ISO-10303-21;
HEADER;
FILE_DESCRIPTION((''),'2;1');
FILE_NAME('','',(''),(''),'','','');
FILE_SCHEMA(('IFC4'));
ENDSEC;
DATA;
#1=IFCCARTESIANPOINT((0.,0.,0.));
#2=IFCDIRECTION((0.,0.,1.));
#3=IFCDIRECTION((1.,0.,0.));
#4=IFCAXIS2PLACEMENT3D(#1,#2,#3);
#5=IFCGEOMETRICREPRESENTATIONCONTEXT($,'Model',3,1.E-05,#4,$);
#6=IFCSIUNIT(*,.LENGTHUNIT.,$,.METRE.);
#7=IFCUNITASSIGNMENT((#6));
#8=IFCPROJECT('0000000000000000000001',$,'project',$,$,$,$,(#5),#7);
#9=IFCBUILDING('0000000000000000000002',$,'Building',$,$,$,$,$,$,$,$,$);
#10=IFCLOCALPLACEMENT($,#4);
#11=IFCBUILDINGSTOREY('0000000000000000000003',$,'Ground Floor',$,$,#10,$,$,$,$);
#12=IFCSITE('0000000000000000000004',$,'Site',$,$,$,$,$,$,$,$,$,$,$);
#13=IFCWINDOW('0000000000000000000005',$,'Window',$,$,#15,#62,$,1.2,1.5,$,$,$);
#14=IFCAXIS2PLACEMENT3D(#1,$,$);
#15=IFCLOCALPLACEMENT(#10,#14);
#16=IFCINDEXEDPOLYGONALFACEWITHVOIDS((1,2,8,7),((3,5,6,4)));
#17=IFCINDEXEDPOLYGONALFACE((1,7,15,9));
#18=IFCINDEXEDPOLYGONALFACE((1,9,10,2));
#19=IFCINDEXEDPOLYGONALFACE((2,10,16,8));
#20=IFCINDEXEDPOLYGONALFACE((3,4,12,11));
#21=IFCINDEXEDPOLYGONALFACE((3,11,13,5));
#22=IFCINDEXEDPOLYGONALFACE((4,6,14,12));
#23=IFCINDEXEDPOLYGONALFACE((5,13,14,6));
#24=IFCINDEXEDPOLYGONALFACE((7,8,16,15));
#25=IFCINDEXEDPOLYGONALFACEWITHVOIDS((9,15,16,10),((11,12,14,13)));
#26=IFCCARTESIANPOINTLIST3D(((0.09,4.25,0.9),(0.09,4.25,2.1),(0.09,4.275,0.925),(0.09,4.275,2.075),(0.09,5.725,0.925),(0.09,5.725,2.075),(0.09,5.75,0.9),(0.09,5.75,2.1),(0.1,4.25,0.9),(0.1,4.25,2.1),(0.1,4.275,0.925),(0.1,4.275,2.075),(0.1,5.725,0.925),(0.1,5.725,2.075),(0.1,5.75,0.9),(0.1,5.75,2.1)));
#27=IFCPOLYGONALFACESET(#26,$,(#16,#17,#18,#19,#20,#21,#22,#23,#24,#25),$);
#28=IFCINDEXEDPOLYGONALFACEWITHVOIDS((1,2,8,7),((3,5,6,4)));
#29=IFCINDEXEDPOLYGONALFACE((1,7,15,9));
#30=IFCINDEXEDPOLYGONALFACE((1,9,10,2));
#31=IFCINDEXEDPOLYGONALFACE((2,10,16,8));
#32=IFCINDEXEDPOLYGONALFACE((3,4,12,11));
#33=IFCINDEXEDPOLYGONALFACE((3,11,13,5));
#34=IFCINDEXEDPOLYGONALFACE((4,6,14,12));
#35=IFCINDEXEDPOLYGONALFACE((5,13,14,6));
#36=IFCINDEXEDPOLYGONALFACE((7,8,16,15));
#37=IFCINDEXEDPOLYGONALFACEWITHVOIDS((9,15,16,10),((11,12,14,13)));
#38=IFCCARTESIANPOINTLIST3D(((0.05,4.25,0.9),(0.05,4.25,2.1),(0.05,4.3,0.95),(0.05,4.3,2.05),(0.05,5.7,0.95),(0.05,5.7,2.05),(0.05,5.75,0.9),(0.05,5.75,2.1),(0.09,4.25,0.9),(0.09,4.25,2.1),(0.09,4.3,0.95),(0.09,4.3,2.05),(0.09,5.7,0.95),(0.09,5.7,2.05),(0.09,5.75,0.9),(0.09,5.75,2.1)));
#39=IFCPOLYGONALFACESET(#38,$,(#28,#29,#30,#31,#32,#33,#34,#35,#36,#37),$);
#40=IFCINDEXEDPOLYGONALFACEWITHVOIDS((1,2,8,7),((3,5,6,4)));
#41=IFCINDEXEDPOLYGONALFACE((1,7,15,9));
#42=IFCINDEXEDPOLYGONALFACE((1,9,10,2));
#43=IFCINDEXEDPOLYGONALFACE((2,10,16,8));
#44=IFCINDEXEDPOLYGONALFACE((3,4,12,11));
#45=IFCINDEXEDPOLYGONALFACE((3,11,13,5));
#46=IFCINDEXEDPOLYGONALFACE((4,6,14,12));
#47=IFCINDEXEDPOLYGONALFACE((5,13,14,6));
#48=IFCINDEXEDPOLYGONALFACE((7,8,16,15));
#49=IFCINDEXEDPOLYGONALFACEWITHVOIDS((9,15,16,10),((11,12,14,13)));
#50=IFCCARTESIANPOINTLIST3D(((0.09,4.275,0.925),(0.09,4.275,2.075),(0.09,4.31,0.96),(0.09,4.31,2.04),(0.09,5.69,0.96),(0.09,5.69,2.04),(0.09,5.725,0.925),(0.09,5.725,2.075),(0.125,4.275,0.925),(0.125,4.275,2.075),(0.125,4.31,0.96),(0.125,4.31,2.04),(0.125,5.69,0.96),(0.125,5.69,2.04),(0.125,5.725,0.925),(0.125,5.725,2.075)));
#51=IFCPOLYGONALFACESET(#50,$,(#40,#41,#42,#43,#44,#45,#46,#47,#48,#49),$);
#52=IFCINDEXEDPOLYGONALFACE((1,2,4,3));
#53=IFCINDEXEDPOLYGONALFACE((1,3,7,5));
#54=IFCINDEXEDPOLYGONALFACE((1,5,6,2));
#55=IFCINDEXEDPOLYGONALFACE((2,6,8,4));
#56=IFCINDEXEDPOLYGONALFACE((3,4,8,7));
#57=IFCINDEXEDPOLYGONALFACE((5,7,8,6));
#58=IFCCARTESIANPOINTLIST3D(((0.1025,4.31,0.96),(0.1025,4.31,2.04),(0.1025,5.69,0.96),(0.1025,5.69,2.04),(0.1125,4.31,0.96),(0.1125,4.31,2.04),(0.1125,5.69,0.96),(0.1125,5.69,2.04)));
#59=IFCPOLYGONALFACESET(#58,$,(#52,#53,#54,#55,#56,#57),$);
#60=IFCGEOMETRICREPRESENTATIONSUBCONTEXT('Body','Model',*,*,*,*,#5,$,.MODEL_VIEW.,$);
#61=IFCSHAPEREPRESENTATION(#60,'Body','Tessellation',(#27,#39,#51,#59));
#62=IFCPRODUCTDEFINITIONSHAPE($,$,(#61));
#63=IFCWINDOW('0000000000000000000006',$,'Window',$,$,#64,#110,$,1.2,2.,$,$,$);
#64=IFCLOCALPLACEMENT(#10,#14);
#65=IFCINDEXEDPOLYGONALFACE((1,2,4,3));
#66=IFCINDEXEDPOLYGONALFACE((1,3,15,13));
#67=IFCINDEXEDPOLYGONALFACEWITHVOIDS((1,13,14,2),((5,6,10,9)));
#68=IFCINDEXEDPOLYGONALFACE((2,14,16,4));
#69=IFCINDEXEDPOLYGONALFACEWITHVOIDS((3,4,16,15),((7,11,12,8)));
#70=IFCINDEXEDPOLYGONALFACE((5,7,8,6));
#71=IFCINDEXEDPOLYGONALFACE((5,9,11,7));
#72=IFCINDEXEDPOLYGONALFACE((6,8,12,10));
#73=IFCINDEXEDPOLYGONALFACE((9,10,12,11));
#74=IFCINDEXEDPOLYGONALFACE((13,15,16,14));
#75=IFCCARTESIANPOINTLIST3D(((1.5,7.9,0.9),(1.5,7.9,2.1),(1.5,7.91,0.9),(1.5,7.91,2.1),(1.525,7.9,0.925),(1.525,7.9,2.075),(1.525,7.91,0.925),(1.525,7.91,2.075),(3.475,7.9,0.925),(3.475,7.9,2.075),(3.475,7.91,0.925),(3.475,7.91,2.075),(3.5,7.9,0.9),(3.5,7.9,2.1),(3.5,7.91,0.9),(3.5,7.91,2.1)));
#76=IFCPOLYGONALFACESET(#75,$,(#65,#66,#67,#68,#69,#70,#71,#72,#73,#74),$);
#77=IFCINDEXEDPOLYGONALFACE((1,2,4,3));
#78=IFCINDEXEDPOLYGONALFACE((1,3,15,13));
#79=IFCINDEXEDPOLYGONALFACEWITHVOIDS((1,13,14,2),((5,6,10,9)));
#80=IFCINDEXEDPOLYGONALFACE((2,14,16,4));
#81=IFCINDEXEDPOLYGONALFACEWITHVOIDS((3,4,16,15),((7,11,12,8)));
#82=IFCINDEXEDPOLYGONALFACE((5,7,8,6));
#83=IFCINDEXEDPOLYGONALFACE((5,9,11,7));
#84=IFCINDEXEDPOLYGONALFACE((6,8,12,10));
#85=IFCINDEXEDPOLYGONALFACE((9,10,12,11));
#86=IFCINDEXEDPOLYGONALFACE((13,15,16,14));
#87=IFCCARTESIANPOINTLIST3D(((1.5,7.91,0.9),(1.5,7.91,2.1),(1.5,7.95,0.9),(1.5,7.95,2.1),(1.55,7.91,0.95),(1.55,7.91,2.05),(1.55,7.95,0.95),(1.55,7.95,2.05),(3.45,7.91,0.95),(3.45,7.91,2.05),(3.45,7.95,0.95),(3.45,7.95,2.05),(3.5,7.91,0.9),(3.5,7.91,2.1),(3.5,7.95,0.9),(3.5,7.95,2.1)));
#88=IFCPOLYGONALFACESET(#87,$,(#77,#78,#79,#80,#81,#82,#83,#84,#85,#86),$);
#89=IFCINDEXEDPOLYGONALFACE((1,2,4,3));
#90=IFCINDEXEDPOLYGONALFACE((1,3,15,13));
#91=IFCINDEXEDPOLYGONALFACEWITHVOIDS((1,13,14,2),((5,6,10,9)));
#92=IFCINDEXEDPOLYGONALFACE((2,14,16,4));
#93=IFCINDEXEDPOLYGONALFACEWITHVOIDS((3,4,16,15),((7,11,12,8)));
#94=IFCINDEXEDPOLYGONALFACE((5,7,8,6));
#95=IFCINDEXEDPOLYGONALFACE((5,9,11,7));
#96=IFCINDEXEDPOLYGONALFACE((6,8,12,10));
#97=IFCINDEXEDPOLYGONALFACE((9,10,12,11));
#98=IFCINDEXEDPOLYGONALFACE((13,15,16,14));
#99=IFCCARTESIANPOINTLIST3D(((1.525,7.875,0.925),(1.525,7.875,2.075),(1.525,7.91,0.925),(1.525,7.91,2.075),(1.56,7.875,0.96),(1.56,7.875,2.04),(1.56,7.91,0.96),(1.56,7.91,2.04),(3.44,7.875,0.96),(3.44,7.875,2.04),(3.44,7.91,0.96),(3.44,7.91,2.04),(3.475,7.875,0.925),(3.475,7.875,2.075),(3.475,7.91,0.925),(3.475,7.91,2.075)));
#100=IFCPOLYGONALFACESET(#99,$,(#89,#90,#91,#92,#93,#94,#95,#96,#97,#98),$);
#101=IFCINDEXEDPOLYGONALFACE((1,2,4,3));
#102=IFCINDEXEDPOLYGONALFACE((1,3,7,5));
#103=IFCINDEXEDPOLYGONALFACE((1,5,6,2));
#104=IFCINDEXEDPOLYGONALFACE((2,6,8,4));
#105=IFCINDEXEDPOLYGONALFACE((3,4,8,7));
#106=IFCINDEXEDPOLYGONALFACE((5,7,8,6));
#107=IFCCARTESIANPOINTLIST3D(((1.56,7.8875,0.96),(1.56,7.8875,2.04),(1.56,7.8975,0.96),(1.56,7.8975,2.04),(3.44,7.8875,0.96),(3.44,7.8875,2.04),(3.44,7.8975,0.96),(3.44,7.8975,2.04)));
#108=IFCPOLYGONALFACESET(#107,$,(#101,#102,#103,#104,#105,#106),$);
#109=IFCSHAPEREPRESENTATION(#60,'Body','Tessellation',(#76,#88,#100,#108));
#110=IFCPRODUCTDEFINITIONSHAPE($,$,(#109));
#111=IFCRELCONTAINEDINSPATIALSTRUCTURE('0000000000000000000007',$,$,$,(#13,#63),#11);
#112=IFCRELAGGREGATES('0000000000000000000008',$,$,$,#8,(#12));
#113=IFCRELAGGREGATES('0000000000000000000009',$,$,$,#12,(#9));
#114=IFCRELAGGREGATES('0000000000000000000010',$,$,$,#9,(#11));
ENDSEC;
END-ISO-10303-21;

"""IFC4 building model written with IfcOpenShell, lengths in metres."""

from ifc_helpers import new_model, si_unit, frame, origin_with_axes, place, context, subcontext, project, spatial, line, indexed_curve, outline, extrude, element, save


model = new_model("IFC4")

# Units and contexts
model_context = context("Model", 3, precision=1e-05, world=origin_with_axes())
body_context = subcontext(model_context, "Body", "Model", "MODEL_VIEW")
ifc_project = project(units=[si_unit("LENGTHUNIT", "METRE")], contexts=[model_context])

# Site, building, storey
site = spatial("IfcSite", under=ifc_project, Name="Site")
building = spatial("IfcBuilding", under=site, Name="Building")
storey_placement = place(None, origin_with_axes())
storey = spatial("IfcBuildingStorey", under=building, at=storey_placement, Name="Ground Floor")

# Windows
for number, where, z_axis, x_axis, name in (
    (1, (0.0, 5.75, 0.9), (0.0, 0.0, 1.0), (0.0, -1.0, 0.0), "Window"),
):
    element("IfcWindow", number, at=place(storey_placement, frame(where, z_axis=z_axis, x_axis=x_axis)), inside=storey, Name=name, OverallHeight=1.2, OverallWidth=1.5, context=body_context, shape_type="SweptSolid", body=[
        extrude(outline(indexed_curve([(0.0, 0.0), (1.5, 0.0), (1.5, 1.2), (0.0, 1.2)], segments=[line(1, 2, 3, 4, 1)]), holes=[indexed_curve([(0.025, 0.025), (1.475, 0.025), (1.475, 1.175), (0.025, 1.175)], segments=[line(1, 2, 3, 4, 1)])]), frame((0.0, 0.09, 0.0), z_axis=(0.0, -1.0, 0.0), x_axis=(1.0, 0.0, 0.0)), (0.0, 0.0, -1.0), 0.01),
        extrude(outline(indexed_curve([(0.0, 0.0), (1.5, 0.0), (1.5, 1.2), (0.0, 1.2)], segments=[line(1, 2, 3, 4, 1)]), holes=[indexed_curve([(0.05, 0.05), (1.45, 0.05), (1.45, 1.15), (0.05, 1.15)], segments=[line(1, 2, 3, 4, 1)])]), frame((0.0, 0.05, 0.0), z_axis=(0.0, -1.0, 0.0), x_axis=(1.0, 0.0, 0.0)), (0.0, 0.0, -1.0), 0.04),
        extrude(outline(indexed_curve([(0.0, 0.0), (1.45, 0.0), (1.45, 1.15), (0.0, 1.15)], segments=[line(1, 2, 3, 4, 1)]), holes=[indexed_curve([(0.035, 0.035), (1.415, 0.035), (1.415, 1.115), (0.035, 1.115)], segments=[line(1, 2, 3, 4, 1)])]), frame((0.025, 0.09, 0.025), z_axis=(0.0, -1.0, 0.0), x_axis=(1.0, 0.0, 0.0)), (0.0, 0.0, -1.0), 0.035),
        extrude(outline(indexed_curve([(0.035, 0.035), (1.415, 0.035), (1.415, 1.115), (0.035, 1.115)], segments=[line(1, 2, 3, 4, 1)])), frame((0.025, 0.1025, 0.025), z_axis=(0.0, -1.0, 0.0), x_axis=(1.0, 0.0, 0.0)), (0.0, 0.0, -1.0), 0.01),
    ])
window_1_placement = place(storey_placement, frame((3.5, 8.0, 0.9), z_axis=(0.0, 0.0, 1.0), x_axis=(-1.0, 0.0, 0.0)))
element("IfcWindow", 2, at=window_1_placement, inside=storey, Name="Window", OverallHeight=1.2, OverallWidth=2.0, context=body_context, shape_type="SweptSolid", body=[
    extrude(outline(indexed_curve([(0.0, 0.0), (2.0, 0.0), (2.0, 1.2), (0.0, 1.2)], segments=[line(1, 2, 3, 4, 1)]), holes=[indexed_curve([(0.025, 0.025), (1.975, 0.025), (1.975, 1.175), (0.025, 1.175)], segments=[line(1, 2, 3, 4, 1)])]), frame((0.0, 0.09, 0.0), z_axis=(0.0, -1.0, 0.0), x_axis=(1.0, 0.0, 0.0)), (0.0, 0.0, -1.0), 0.01),
    extrude(outline(indexed_curve([(0.0, 0.0), (2.0, 0.0), (2.0, 1.2), (0.0, 1.2)], segments=[line(1, 2, 3, 4, 1)]), holes=[indexed_curve([(0.05, 0.05), (1.95, 0.05), (1.95, 1.15), (0.05, 1.15)], segments=[line(1, 2, 3, 4, 1)])]), frame((0.0, 0.05, 0.0), z_axis=(0.0, -1.0, 0.0), x_axis=(1.0, 0.0, 0.0)), (0.0, 0.0, -1.0), 0.04),
    extrude(outline(indexed_curve([(0.0, 0.0), (1.95, 0.0), (1.95, 1.15), (0.0, 1.15)], segments=[line(1, 2, 3, 4, 1)]), holes=[indexed_curve([(0.035, 0.035), (1.915, 0.035), (1.915, 1.115), (0.035, 1.115)], segments=[line(1, 2, 3, 4, 1)])]), frame((0.025, 0.09, 0.025), z_axis=(0.0, -1.0, 0.0), x_axis=(1.0, 0.0, 0.0)), (0.0, 0.0, -1.0), 0.035),
    extrude(outline(indexed_curve([(0.035, 0.035), (1.915, 0.035), (1.915, 1.115), (0.035, 1.115)], segments=[line(1, 2, 3, 4, 1)])), frame((0.025, 0.1025, 0.025), z_axis=(0.0, -1.0, 0.0), x_axis=(1.0, 0.0, 0.0)), (0.0, 0.0, -1.0), 0.01),
])

save(model, "model.ifc")
